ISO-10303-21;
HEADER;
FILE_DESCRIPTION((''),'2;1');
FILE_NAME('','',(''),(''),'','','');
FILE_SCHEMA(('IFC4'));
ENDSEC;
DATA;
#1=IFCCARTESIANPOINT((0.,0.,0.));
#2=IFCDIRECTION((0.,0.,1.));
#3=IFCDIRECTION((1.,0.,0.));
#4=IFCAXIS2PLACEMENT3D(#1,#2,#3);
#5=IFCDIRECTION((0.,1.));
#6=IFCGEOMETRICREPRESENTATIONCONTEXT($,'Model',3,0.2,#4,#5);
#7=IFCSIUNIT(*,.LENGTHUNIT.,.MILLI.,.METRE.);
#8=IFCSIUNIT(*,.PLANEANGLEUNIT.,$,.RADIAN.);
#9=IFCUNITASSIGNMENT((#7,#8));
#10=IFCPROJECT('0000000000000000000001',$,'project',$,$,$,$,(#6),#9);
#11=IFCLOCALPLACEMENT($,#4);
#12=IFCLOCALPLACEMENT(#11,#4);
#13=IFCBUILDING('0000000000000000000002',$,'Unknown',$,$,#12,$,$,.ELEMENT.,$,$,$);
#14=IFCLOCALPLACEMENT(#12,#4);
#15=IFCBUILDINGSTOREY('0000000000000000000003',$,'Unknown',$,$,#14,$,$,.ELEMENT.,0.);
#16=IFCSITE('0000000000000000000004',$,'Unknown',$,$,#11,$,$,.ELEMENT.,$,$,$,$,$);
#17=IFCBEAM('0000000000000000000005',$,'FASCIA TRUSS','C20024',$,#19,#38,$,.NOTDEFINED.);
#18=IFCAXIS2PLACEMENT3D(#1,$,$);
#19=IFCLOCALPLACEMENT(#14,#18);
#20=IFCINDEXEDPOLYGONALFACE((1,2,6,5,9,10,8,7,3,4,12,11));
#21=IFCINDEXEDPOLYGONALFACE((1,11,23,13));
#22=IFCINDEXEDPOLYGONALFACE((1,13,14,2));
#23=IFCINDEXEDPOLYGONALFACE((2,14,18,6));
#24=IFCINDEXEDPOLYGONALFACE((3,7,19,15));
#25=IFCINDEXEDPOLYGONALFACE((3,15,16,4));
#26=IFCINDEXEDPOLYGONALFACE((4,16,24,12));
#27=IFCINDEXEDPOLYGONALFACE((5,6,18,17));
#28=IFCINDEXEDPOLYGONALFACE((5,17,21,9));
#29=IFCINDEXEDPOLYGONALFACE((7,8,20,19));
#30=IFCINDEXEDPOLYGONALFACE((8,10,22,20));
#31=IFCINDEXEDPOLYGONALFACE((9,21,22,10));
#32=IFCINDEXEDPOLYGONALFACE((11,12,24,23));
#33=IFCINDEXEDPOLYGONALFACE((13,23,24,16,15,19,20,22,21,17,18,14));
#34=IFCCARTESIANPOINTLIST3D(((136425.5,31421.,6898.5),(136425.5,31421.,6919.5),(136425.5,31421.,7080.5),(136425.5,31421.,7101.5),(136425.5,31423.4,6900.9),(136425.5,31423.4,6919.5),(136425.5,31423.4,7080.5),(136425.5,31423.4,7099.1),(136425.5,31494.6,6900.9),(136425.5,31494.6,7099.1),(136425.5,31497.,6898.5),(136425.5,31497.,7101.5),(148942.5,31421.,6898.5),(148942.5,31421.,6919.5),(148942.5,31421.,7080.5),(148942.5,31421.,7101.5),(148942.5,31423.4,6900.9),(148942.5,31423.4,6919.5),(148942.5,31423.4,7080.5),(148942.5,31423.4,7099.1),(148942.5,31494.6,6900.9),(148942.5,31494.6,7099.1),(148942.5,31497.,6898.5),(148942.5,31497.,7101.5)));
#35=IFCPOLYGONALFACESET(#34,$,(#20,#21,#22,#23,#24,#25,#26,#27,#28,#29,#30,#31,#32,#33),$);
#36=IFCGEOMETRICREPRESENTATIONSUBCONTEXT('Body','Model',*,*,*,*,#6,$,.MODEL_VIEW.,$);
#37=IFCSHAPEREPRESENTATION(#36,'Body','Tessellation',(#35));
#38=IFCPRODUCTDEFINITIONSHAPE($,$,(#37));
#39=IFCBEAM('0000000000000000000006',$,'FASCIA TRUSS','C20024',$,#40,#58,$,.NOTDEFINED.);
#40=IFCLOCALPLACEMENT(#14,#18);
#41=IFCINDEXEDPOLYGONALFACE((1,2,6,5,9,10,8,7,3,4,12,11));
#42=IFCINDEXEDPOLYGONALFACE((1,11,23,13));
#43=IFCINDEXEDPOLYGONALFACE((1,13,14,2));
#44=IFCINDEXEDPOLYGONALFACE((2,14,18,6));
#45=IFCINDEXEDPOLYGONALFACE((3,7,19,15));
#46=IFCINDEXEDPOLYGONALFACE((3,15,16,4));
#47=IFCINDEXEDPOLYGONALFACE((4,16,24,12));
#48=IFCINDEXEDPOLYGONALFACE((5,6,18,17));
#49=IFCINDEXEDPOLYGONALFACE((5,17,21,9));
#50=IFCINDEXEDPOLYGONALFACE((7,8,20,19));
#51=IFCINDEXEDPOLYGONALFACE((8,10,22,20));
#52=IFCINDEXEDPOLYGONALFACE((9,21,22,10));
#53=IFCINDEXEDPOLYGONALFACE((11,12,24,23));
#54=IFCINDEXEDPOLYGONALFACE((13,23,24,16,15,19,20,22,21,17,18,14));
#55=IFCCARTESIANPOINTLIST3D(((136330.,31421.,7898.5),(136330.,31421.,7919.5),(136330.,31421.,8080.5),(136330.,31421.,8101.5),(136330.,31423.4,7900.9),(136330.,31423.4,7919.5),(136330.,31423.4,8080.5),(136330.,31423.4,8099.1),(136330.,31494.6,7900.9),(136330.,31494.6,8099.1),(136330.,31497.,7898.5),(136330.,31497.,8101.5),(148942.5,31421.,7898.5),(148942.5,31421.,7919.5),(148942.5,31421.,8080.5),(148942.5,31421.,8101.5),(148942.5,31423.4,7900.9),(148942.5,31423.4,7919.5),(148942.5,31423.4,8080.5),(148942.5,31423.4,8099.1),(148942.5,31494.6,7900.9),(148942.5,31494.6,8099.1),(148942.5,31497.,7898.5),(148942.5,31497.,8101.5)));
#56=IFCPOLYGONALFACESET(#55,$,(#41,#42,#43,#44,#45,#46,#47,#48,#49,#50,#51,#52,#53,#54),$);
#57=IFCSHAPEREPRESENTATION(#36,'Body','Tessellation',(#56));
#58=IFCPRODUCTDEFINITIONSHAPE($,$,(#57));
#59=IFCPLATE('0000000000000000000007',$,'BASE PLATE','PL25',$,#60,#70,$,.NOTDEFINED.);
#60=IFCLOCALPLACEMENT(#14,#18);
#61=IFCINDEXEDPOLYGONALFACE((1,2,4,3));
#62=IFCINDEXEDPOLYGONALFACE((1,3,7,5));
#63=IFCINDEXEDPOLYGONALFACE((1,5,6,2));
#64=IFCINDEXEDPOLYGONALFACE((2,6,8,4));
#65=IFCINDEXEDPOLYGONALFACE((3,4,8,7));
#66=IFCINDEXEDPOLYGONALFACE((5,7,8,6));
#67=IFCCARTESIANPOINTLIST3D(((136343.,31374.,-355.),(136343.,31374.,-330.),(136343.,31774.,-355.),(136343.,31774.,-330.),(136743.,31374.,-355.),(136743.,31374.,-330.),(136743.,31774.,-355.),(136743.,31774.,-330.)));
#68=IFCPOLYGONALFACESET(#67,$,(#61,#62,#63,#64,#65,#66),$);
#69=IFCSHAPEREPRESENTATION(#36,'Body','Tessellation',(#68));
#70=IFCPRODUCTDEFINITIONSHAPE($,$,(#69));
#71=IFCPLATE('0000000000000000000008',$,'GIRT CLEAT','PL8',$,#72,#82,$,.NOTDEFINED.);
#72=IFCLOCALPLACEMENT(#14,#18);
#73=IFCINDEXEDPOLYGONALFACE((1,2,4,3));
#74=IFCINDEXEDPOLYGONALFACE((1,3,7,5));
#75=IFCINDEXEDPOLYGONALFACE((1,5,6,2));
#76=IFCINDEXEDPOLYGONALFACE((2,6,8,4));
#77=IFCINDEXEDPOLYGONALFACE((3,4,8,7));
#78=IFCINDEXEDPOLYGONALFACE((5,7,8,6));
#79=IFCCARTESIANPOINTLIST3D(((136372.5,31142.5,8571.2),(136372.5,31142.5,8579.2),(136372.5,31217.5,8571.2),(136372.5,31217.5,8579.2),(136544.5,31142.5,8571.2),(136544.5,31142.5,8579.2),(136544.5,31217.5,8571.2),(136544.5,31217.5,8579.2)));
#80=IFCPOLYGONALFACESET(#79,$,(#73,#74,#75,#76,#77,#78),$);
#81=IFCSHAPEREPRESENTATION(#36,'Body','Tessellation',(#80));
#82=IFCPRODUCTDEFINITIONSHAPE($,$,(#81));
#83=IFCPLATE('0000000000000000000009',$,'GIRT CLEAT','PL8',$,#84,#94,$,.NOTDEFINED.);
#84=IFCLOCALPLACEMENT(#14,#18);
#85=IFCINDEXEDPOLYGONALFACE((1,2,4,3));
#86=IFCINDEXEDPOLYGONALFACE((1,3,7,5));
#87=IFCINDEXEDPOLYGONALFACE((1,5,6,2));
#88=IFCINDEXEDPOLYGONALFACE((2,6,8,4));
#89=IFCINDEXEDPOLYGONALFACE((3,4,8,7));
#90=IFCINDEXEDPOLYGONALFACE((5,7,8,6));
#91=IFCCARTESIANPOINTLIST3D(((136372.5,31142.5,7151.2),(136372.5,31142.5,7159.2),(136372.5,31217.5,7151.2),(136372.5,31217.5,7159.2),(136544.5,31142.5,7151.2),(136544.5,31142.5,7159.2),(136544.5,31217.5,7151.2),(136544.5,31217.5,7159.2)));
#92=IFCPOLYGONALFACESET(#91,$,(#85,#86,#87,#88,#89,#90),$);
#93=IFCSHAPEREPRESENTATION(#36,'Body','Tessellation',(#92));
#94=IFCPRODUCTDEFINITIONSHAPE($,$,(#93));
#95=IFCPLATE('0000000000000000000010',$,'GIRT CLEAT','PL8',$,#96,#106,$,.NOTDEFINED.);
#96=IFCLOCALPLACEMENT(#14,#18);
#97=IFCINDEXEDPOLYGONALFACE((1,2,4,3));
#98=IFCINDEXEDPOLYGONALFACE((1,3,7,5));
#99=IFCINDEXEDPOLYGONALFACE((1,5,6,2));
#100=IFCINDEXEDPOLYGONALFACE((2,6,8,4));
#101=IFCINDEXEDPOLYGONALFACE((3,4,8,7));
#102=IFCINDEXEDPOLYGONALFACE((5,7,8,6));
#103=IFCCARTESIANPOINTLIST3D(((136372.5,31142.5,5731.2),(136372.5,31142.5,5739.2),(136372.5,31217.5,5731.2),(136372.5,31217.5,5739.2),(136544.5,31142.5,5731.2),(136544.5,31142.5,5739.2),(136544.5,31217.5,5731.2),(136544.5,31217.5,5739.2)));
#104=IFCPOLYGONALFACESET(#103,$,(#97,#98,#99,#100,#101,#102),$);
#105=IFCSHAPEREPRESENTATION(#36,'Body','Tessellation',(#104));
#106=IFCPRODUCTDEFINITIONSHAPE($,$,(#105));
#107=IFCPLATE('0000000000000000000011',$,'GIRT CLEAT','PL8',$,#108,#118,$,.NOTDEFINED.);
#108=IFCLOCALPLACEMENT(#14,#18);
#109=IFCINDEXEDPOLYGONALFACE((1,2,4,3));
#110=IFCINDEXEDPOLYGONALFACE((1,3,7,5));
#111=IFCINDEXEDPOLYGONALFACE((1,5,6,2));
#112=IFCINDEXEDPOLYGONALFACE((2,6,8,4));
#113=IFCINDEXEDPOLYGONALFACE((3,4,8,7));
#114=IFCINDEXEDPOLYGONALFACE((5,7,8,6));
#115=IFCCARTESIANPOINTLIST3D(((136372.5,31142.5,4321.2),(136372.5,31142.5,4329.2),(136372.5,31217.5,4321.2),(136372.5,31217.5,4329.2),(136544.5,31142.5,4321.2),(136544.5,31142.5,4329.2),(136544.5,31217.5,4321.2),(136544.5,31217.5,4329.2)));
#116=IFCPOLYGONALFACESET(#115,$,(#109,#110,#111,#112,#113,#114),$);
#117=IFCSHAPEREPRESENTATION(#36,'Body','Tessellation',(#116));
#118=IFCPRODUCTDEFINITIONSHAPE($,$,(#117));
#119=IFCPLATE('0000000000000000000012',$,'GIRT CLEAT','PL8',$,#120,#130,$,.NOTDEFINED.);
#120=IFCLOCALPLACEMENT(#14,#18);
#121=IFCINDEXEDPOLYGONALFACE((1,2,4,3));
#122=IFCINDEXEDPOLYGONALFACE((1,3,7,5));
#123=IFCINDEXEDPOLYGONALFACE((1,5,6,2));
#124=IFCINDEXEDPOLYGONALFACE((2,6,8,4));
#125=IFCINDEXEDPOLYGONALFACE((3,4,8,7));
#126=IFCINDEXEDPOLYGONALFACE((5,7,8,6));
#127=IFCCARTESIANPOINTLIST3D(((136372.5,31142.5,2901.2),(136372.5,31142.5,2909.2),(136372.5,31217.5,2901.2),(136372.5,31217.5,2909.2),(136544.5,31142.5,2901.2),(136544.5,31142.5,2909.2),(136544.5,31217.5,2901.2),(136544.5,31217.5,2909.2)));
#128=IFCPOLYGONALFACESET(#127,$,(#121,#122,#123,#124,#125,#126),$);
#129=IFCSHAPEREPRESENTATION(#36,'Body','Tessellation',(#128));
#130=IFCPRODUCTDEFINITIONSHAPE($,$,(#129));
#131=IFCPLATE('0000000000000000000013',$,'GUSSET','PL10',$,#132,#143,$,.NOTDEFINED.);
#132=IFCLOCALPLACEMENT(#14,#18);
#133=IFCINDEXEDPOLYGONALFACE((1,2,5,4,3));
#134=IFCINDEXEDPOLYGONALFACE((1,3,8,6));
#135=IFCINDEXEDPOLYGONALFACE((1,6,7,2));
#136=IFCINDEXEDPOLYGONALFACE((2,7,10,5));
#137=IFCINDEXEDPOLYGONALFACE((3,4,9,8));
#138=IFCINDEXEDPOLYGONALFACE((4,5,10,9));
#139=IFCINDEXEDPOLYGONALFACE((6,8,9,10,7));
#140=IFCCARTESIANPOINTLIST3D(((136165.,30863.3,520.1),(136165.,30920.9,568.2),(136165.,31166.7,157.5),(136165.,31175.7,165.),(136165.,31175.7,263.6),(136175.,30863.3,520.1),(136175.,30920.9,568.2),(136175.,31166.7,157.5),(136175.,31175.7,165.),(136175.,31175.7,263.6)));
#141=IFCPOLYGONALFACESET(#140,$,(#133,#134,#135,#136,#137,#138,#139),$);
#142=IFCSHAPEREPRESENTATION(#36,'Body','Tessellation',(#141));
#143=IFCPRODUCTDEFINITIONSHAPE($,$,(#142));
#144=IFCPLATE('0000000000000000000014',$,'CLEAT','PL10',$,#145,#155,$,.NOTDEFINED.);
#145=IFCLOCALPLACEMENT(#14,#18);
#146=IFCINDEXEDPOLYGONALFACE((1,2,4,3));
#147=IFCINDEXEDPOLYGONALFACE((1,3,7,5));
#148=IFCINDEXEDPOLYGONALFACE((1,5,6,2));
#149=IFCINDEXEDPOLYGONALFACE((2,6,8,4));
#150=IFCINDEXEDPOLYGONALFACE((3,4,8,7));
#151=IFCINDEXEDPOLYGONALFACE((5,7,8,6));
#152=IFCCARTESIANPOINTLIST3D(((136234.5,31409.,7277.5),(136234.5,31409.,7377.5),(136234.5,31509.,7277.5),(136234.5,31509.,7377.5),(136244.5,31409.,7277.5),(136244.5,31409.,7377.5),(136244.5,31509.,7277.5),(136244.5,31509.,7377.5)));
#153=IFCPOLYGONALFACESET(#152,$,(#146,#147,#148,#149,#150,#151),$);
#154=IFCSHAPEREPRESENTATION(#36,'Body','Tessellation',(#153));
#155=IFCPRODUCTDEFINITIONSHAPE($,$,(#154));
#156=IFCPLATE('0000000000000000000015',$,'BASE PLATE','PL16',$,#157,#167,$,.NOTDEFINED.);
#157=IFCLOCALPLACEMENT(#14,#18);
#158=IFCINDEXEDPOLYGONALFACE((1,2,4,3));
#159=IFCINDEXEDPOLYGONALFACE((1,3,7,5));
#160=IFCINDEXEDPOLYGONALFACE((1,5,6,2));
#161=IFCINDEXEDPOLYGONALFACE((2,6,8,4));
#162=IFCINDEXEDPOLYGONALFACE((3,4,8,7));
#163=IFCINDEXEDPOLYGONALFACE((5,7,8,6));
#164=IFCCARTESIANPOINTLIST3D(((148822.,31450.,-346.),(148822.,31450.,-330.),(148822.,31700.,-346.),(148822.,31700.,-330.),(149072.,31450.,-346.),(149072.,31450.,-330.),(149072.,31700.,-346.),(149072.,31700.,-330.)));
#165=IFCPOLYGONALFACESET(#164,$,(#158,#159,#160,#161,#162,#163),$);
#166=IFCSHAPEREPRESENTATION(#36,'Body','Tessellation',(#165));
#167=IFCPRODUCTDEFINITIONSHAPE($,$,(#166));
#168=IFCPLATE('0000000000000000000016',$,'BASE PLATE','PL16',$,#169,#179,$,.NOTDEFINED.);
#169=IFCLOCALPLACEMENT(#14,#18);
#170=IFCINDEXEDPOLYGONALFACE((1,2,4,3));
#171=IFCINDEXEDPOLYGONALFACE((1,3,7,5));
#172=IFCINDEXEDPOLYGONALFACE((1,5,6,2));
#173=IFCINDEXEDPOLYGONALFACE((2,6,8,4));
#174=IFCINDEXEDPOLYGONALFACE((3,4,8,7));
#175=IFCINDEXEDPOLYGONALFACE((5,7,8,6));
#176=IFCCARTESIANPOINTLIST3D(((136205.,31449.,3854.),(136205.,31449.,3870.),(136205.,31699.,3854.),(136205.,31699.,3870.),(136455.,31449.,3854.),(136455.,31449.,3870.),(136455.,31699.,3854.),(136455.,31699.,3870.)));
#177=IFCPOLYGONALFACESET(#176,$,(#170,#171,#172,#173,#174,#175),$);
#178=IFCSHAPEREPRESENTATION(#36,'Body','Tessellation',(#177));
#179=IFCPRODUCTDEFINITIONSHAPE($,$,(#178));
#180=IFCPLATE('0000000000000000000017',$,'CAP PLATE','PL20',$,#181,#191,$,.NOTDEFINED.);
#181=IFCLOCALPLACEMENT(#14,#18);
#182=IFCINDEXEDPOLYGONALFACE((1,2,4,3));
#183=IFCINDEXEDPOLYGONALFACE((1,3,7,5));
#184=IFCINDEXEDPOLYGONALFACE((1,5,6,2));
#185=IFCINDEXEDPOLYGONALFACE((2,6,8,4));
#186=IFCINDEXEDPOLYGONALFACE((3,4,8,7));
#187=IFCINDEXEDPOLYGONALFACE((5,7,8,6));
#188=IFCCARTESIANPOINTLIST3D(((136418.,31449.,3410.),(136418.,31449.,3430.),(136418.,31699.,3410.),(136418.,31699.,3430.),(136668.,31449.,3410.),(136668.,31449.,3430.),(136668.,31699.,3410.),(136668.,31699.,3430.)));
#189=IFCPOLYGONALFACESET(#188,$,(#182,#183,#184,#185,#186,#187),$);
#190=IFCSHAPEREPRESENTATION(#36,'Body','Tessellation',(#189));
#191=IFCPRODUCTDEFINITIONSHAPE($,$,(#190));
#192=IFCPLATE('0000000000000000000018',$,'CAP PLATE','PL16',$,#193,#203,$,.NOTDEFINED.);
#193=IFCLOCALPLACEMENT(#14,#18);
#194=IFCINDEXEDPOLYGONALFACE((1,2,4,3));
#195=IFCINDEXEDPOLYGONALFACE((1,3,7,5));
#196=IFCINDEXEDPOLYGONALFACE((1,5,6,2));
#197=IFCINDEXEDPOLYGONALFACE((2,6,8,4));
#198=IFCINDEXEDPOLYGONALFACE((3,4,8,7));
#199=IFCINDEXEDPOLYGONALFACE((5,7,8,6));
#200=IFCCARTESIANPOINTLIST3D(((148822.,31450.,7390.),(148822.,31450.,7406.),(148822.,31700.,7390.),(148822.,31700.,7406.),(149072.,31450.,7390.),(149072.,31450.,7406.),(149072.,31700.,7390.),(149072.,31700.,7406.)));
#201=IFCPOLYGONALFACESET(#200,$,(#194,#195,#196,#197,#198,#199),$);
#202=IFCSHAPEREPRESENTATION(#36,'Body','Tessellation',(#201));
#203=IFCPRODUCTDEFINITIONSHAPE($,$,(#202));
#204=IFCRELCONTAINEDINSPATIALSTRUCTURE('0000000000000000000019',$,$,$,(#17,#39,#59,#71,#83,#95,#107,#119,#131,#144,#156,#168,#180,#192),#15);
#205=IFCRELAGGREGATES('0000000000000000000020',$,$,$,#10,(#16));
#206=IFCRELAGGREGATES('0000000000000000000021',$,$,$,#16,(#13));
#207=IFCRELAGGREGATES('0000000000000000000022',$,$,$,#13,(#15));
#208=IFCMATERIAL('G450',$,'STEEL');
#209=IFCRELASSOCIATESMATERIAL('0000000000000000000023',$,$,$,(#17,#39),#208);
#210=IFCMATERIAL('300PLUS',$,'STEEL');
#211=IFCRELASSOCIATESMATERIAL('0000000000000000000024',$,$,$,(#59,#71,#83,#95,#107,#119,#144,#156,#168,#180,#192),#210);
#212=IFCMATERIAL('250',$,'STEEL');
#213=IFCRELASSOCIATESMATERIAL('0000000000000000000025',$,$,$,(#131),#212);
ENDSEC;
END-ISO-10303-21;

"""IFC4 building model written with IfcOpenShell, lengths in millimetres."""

from ifc_helpers import new_model, si_unit, direction, frame, origin_with_axes, place, context, subcontext, project, spatial, line, indexed_curve, outline, extrude, material, element, save


model = new_model("IFC4")

# Units and contexts
model_context = context("Model", 3, precision=0.2, world=origin_with_axes(), true_north=direction((0.0, 1.0)))
body_context = subcontext(model_context, "Body", "Model", "MODEL_VIEW")
ifc_project = project(units=[si_unit("LENGTHUNIT", "METRE", prefix="MILLI"), si_unit("PLANEANGLEUNIT", "RADIAN")], contexts=[model_context])

# Site, building, storey
site_placement = place(None, origin_with_axes())
site = spatial("IfcSite", under=ifc_project, at=site_placement, Name="Unknown", CompositionType="ELEMENT")
building_placement = place(site_placement, origin_with_axes())
building = spatial("IfcBuilding", under=site, at=building_placement, Name="Unknown", CompositionType="ELEMENT")
storey_placement = place(building_placement, origin_with_axes())
storey = spatial("IfcBuildingStorey", under=building, at=storey_placement, Name="Unknown", CompositionType="ELEMENT", Elevation=0.0)

# Shared definitions
ifc_material_1 = material(Name="G450", Category="STEEL")
ifc_material_2 = material(Name="300PLUS", Category="STEEL")

# Beams
beam_1_placement = place(storey_placement, frame((136425.5, 31459.0, 7000.0), z_axis=(0.0, -1.0, 0.0), x_axis=(1.0, 0.0, 0.0)))
element("IfcBeam", 1, at=beam_1_placement, inside=storey, material=ifc_material_1, Name="FASCIA TRUSS", Description="C20024", PredefinedType="NOTDEFINED", context=body_context, shape_type="SolidModel", body=[
    extrude(outline(indexed_curve([(38.0, -101.5), (38.0, -80.5), (35.6, -80.5), (35.6, -99.1), (-35.6, -99.1), (-35.6, 99.1), (35.6, 99.1), (35.6, 80.5), (38.0, 80.5), (38.0, 101.5), (-38.0, 101.5), (-38.0, -101.5)], segments=[line(1, 2, 3, 4, 5, 6, 7, 8, 9, 10, 11, 12, 1)])), frame((0.0, 0.0, 0.0), z_axis=(-1.0, 0.0, 0.0), x_axis=(0.0, 0.0, 1.0)), (0.0, 0.0, -1.0), 12517.0),
])
beam_2_placement = place(storey_placement, frame((136330.0, 31459.0, 8000.0), z_axis=(0.0, -1.0, 0.0), x_axis=(1.0, 0.0, 0.0)))
element("IfcBeam", 2, at=beam_2_placement, inside=storey, material=ifc_material_1, Name="FASCIA TRUSS", Description="C20024", PredefinedType="NOTDEFINED", context=body_context, shape_type="SolidModel", body=[
    extrude(outline(indexed_curve([(38.0, -101.5), (38.0, -80.5), (35.6, -80.5), (35.6, -99.1), (-35.6, -99.1), (-35.6, 99.1), (35.6, 99.1), (35.6, 80.5), (38.0, 80.5), (38.0, 101.5), (-38.0, 101.5), (-38.0, -101.5)], segments=[line(1, 2, 3, 4, 5, 6, 7, 8, 9, 10, 11, 12, 1)])), frame((0.0, 0.0, 0.0), z_axis=(-1.0, 0.0, 0.0), x_axis=(0.0, 0.0, 1.0)), (0.0, 0.0, -1.0), 12612.5),
])

# Plates
plate_1_placement = place(storey_placement, frame((136343.0, 31374.0, -342.5), z_axis=(0.0, 0.0, 1.0), x_axis=(1.0, 0.0, 0.0)))
element("IfcPlate", 3, at=plate_1_placement, inside=storey, material=ifc_material_2, Name="BASE PLATE", Description="PL25", PredefinedType="NOTDEFINED", context=body_context, shape_type="SolidModel", body=[
    extrude(outline(indexed_curve([(0.0, 0.0), (400.0, 0.0), (400.0, 400.0), (0.0, 400.0)], segments=[line(1, 2, 3, 4, 1)])), frame((0.0, 0.0, 12.5), z_axis=(0.0, 0.0, 1.0), x_axis=(1.0, 0.0, 0.0)), (0.0, 0.0, -1.0), 25.0),
])
for number, where, z_axis, x_axis, name in (
    (4, (136544.5, 31142.5, 8575.2), (0.0, 0.0, 1.0), (0.0, 1.0, 0.0), "GIRT CLEAT"),
    (5, (136544.5, 31142.5, 7155.2), (0.0, 0.0, 1.0), (0.0, 1.0, 0.0), "GIRT CLEAT"),
    (6, (136544.5, 31142.5, 5735.2), (0.0, 0.0, 1.0), (0.0, 1.0, 0.0), "GIRT CLEAT"),
    (7, (136544.5, 31142.5, 4325.2), (0.0, 0.0, 1.0), (0.0, 1.0, 0.0), "GIRT CLEAT"),
    (8, (136544.5, 31142.5, 2905.2), (0.0, 0.0, 1.0), (0.0, 1.0, 0.0), "GIRT CLEAT"),
):
    element("IfcPlate", number, at=place(storey_placement, frame(where, z_axis=z_axis, x_axis=x_axis)), inside=storey, material=ifc_material_2, Name=name, Description="PL8", PredefinedType="NOTDEFINED", context=body_context, shape_type="SolidModel", body=[
        extrude(outline(indexed_curve([(0.0, 0.0), (75.0, 0.0), (75.0, 172.0), (0.0, 172.0)], segments=[line(1, 2, 3, 4, 1)])), frame((0.0, 0.0, 4.0), z_axis=(0.0, 0.0, 1.0), x_axis=(1.0, 0.0, 0.0)), (0.0, 0.0, -1.0), 8.0),
    ])
ifc_material_3 = material(Name="250", Category="STEEL")
plate_2_placement = place(storey_placement, frame((136170.0, 31175.7, 165.0), z_axis=(-1.0, 0.0, 0.0), x_axis=(0.0, -0.768221, -0.640184)))
element("IfcPlate", 9, at=plate_2_placement, inside=storey, material=ifc_material_3, Name="GUSSET", Description="PL10", PredefinedType="NOTDEFINED", context=body_context, shape_type="SolidModel", body=[
    extrude(outline(indexed_curve([(0.0, 0.0), (11.7, 0.0), (12.7, 472.8), (-62.4, 472.9), (-63.1, 75.7)], segments=[line(1, 2, 3, 4, 5, 1)])), frame((0.0, 0.0, 5.0), z_axis=(0.0, 0.0, 1.0), x_axis=(1.0, 0.0, 0.0)), (0.0, 0.0, -1.0), 10.0),
])
plate_3_placement = place(storey_placement, frame((136239.5, 31409.0, 7277.5), z_axis=(1.0, 0.0, 0.0), x_axis=(0.0, 1.0, 0.0)))
element("IfcPlate", 10, at=plate_3_placement, inside=storey, material=ifc_material_2, Name="CLEAT", Description="PL10", PredefinedType="NOTDEFINED", context=body_context, shape_type="SolidModel", body=[
    extrude(outline(indexed_curve([(0.0, 0.0), (100.0, 0.0), (100.0, 100.0), (0.0, 100.0)], segments=[line(1, 2, 3, 4, 1)])), frame((0.0, 0.0, 5.0), z_axis=(0.0, 0.0, 1.0), x_axis=(1.0, 0.0, 0.0)), (0.0, 0.0, -1.0), 10.0),
])
for number, where, z_axis, x_axis, name in (
    (11, (148822.0, 31450.0, -338.0), (0.0, 0.0, 1.0), (1.0, 0.0, 0.0), "BASE PLATE"),
    (12, (136205.0, 31449.0, 3862.0), (0.0, 0.0, 1.0), (1.0, 0.0, 0.0), "BASE PLATE"),
):
    element("IfcPlate", number, at=place(storey_placement, frame(where, z_axis=z_axis, x_axis=x_axis)), inside=storey, material=ifc_material_2, Name=name, Description="PL16", PredefinedType="NOTDEFINED", context=body_context, shape_type="SolidModel", body=[
        extrude(outline(indexed_curve([(0.0, 0.0), (250.0, 0.0), (250.0, 250.0), (0.0, 250.0)], segments=[line(1, 2, 3, 4, 1)])), frame((0.0, 0.0, 8.0), z_axis=(0.0, 0.0, 1.0), x_axis=(1.0, 0.0, 0.0)), (0.0, 0.0, -1.0), 16.0),
    ])
plate_4_placement = place(storey_placement, frame((136418.0, 31449.0, 3420.0), z_axis=(0.0, 0.0, 1.0), x_axis=(1.0, 0.0, 0.0)))
element("IfcPlate", 13, at=plate_4_placement, inside=storey, material=ifc_material_2, Name="CAP PLATE", Description="PL20", PredefinedType="NOTDEFINED", context=body_context, shape_type="SolidModel", body=[
    extrude(outline(indexed_curve([(0.0, 0.0), (250.0, 0.0), (250.0, 250.0), (0.0, 250.0)], segments=[line(1, 2, 3, 4, 1)])), frame((0.0, 0.0, 10.0), z_axis=(0.0, 0.0, 1.0), x_axis=(1.0, 0.0, 0.0)), (0.0, 0.0, -1.0), 20.0),
])
for number, where, z_axis, x_axis, name in (
    (14, (148822.0, 31450.0, 7398.0), (0.0, 0.0, 1.0), (1.0, 0.0, 0.0), "CAP PLATE"),
):
    element("IfcPlate", number, at=place(storey_placement, frame(where, z_axis=z_axis, x_axis=x_axis)), inside=storey, material=ifc_material_2, Name=name, Description="PL16", PredefinedType="NOTDEFINED", context=body_context, shape_type="SolidModel", body=[
        extrude(outline(indexed_curve([(0.0, 0.0), (250.0, 0.0), (250.0, 250.0), (0.0, 250.0)], segments=[line(1, 2, 3, 4, 1)])), frame((0.0, 0.0, 8.0), z_axis=(0.0, 0.0, 1.0), x_axis=(1.0, 0.0, 0.0)), (0.0, 0.0, -1.0), 16.0),
    ])

save(model, "model.ifc")
